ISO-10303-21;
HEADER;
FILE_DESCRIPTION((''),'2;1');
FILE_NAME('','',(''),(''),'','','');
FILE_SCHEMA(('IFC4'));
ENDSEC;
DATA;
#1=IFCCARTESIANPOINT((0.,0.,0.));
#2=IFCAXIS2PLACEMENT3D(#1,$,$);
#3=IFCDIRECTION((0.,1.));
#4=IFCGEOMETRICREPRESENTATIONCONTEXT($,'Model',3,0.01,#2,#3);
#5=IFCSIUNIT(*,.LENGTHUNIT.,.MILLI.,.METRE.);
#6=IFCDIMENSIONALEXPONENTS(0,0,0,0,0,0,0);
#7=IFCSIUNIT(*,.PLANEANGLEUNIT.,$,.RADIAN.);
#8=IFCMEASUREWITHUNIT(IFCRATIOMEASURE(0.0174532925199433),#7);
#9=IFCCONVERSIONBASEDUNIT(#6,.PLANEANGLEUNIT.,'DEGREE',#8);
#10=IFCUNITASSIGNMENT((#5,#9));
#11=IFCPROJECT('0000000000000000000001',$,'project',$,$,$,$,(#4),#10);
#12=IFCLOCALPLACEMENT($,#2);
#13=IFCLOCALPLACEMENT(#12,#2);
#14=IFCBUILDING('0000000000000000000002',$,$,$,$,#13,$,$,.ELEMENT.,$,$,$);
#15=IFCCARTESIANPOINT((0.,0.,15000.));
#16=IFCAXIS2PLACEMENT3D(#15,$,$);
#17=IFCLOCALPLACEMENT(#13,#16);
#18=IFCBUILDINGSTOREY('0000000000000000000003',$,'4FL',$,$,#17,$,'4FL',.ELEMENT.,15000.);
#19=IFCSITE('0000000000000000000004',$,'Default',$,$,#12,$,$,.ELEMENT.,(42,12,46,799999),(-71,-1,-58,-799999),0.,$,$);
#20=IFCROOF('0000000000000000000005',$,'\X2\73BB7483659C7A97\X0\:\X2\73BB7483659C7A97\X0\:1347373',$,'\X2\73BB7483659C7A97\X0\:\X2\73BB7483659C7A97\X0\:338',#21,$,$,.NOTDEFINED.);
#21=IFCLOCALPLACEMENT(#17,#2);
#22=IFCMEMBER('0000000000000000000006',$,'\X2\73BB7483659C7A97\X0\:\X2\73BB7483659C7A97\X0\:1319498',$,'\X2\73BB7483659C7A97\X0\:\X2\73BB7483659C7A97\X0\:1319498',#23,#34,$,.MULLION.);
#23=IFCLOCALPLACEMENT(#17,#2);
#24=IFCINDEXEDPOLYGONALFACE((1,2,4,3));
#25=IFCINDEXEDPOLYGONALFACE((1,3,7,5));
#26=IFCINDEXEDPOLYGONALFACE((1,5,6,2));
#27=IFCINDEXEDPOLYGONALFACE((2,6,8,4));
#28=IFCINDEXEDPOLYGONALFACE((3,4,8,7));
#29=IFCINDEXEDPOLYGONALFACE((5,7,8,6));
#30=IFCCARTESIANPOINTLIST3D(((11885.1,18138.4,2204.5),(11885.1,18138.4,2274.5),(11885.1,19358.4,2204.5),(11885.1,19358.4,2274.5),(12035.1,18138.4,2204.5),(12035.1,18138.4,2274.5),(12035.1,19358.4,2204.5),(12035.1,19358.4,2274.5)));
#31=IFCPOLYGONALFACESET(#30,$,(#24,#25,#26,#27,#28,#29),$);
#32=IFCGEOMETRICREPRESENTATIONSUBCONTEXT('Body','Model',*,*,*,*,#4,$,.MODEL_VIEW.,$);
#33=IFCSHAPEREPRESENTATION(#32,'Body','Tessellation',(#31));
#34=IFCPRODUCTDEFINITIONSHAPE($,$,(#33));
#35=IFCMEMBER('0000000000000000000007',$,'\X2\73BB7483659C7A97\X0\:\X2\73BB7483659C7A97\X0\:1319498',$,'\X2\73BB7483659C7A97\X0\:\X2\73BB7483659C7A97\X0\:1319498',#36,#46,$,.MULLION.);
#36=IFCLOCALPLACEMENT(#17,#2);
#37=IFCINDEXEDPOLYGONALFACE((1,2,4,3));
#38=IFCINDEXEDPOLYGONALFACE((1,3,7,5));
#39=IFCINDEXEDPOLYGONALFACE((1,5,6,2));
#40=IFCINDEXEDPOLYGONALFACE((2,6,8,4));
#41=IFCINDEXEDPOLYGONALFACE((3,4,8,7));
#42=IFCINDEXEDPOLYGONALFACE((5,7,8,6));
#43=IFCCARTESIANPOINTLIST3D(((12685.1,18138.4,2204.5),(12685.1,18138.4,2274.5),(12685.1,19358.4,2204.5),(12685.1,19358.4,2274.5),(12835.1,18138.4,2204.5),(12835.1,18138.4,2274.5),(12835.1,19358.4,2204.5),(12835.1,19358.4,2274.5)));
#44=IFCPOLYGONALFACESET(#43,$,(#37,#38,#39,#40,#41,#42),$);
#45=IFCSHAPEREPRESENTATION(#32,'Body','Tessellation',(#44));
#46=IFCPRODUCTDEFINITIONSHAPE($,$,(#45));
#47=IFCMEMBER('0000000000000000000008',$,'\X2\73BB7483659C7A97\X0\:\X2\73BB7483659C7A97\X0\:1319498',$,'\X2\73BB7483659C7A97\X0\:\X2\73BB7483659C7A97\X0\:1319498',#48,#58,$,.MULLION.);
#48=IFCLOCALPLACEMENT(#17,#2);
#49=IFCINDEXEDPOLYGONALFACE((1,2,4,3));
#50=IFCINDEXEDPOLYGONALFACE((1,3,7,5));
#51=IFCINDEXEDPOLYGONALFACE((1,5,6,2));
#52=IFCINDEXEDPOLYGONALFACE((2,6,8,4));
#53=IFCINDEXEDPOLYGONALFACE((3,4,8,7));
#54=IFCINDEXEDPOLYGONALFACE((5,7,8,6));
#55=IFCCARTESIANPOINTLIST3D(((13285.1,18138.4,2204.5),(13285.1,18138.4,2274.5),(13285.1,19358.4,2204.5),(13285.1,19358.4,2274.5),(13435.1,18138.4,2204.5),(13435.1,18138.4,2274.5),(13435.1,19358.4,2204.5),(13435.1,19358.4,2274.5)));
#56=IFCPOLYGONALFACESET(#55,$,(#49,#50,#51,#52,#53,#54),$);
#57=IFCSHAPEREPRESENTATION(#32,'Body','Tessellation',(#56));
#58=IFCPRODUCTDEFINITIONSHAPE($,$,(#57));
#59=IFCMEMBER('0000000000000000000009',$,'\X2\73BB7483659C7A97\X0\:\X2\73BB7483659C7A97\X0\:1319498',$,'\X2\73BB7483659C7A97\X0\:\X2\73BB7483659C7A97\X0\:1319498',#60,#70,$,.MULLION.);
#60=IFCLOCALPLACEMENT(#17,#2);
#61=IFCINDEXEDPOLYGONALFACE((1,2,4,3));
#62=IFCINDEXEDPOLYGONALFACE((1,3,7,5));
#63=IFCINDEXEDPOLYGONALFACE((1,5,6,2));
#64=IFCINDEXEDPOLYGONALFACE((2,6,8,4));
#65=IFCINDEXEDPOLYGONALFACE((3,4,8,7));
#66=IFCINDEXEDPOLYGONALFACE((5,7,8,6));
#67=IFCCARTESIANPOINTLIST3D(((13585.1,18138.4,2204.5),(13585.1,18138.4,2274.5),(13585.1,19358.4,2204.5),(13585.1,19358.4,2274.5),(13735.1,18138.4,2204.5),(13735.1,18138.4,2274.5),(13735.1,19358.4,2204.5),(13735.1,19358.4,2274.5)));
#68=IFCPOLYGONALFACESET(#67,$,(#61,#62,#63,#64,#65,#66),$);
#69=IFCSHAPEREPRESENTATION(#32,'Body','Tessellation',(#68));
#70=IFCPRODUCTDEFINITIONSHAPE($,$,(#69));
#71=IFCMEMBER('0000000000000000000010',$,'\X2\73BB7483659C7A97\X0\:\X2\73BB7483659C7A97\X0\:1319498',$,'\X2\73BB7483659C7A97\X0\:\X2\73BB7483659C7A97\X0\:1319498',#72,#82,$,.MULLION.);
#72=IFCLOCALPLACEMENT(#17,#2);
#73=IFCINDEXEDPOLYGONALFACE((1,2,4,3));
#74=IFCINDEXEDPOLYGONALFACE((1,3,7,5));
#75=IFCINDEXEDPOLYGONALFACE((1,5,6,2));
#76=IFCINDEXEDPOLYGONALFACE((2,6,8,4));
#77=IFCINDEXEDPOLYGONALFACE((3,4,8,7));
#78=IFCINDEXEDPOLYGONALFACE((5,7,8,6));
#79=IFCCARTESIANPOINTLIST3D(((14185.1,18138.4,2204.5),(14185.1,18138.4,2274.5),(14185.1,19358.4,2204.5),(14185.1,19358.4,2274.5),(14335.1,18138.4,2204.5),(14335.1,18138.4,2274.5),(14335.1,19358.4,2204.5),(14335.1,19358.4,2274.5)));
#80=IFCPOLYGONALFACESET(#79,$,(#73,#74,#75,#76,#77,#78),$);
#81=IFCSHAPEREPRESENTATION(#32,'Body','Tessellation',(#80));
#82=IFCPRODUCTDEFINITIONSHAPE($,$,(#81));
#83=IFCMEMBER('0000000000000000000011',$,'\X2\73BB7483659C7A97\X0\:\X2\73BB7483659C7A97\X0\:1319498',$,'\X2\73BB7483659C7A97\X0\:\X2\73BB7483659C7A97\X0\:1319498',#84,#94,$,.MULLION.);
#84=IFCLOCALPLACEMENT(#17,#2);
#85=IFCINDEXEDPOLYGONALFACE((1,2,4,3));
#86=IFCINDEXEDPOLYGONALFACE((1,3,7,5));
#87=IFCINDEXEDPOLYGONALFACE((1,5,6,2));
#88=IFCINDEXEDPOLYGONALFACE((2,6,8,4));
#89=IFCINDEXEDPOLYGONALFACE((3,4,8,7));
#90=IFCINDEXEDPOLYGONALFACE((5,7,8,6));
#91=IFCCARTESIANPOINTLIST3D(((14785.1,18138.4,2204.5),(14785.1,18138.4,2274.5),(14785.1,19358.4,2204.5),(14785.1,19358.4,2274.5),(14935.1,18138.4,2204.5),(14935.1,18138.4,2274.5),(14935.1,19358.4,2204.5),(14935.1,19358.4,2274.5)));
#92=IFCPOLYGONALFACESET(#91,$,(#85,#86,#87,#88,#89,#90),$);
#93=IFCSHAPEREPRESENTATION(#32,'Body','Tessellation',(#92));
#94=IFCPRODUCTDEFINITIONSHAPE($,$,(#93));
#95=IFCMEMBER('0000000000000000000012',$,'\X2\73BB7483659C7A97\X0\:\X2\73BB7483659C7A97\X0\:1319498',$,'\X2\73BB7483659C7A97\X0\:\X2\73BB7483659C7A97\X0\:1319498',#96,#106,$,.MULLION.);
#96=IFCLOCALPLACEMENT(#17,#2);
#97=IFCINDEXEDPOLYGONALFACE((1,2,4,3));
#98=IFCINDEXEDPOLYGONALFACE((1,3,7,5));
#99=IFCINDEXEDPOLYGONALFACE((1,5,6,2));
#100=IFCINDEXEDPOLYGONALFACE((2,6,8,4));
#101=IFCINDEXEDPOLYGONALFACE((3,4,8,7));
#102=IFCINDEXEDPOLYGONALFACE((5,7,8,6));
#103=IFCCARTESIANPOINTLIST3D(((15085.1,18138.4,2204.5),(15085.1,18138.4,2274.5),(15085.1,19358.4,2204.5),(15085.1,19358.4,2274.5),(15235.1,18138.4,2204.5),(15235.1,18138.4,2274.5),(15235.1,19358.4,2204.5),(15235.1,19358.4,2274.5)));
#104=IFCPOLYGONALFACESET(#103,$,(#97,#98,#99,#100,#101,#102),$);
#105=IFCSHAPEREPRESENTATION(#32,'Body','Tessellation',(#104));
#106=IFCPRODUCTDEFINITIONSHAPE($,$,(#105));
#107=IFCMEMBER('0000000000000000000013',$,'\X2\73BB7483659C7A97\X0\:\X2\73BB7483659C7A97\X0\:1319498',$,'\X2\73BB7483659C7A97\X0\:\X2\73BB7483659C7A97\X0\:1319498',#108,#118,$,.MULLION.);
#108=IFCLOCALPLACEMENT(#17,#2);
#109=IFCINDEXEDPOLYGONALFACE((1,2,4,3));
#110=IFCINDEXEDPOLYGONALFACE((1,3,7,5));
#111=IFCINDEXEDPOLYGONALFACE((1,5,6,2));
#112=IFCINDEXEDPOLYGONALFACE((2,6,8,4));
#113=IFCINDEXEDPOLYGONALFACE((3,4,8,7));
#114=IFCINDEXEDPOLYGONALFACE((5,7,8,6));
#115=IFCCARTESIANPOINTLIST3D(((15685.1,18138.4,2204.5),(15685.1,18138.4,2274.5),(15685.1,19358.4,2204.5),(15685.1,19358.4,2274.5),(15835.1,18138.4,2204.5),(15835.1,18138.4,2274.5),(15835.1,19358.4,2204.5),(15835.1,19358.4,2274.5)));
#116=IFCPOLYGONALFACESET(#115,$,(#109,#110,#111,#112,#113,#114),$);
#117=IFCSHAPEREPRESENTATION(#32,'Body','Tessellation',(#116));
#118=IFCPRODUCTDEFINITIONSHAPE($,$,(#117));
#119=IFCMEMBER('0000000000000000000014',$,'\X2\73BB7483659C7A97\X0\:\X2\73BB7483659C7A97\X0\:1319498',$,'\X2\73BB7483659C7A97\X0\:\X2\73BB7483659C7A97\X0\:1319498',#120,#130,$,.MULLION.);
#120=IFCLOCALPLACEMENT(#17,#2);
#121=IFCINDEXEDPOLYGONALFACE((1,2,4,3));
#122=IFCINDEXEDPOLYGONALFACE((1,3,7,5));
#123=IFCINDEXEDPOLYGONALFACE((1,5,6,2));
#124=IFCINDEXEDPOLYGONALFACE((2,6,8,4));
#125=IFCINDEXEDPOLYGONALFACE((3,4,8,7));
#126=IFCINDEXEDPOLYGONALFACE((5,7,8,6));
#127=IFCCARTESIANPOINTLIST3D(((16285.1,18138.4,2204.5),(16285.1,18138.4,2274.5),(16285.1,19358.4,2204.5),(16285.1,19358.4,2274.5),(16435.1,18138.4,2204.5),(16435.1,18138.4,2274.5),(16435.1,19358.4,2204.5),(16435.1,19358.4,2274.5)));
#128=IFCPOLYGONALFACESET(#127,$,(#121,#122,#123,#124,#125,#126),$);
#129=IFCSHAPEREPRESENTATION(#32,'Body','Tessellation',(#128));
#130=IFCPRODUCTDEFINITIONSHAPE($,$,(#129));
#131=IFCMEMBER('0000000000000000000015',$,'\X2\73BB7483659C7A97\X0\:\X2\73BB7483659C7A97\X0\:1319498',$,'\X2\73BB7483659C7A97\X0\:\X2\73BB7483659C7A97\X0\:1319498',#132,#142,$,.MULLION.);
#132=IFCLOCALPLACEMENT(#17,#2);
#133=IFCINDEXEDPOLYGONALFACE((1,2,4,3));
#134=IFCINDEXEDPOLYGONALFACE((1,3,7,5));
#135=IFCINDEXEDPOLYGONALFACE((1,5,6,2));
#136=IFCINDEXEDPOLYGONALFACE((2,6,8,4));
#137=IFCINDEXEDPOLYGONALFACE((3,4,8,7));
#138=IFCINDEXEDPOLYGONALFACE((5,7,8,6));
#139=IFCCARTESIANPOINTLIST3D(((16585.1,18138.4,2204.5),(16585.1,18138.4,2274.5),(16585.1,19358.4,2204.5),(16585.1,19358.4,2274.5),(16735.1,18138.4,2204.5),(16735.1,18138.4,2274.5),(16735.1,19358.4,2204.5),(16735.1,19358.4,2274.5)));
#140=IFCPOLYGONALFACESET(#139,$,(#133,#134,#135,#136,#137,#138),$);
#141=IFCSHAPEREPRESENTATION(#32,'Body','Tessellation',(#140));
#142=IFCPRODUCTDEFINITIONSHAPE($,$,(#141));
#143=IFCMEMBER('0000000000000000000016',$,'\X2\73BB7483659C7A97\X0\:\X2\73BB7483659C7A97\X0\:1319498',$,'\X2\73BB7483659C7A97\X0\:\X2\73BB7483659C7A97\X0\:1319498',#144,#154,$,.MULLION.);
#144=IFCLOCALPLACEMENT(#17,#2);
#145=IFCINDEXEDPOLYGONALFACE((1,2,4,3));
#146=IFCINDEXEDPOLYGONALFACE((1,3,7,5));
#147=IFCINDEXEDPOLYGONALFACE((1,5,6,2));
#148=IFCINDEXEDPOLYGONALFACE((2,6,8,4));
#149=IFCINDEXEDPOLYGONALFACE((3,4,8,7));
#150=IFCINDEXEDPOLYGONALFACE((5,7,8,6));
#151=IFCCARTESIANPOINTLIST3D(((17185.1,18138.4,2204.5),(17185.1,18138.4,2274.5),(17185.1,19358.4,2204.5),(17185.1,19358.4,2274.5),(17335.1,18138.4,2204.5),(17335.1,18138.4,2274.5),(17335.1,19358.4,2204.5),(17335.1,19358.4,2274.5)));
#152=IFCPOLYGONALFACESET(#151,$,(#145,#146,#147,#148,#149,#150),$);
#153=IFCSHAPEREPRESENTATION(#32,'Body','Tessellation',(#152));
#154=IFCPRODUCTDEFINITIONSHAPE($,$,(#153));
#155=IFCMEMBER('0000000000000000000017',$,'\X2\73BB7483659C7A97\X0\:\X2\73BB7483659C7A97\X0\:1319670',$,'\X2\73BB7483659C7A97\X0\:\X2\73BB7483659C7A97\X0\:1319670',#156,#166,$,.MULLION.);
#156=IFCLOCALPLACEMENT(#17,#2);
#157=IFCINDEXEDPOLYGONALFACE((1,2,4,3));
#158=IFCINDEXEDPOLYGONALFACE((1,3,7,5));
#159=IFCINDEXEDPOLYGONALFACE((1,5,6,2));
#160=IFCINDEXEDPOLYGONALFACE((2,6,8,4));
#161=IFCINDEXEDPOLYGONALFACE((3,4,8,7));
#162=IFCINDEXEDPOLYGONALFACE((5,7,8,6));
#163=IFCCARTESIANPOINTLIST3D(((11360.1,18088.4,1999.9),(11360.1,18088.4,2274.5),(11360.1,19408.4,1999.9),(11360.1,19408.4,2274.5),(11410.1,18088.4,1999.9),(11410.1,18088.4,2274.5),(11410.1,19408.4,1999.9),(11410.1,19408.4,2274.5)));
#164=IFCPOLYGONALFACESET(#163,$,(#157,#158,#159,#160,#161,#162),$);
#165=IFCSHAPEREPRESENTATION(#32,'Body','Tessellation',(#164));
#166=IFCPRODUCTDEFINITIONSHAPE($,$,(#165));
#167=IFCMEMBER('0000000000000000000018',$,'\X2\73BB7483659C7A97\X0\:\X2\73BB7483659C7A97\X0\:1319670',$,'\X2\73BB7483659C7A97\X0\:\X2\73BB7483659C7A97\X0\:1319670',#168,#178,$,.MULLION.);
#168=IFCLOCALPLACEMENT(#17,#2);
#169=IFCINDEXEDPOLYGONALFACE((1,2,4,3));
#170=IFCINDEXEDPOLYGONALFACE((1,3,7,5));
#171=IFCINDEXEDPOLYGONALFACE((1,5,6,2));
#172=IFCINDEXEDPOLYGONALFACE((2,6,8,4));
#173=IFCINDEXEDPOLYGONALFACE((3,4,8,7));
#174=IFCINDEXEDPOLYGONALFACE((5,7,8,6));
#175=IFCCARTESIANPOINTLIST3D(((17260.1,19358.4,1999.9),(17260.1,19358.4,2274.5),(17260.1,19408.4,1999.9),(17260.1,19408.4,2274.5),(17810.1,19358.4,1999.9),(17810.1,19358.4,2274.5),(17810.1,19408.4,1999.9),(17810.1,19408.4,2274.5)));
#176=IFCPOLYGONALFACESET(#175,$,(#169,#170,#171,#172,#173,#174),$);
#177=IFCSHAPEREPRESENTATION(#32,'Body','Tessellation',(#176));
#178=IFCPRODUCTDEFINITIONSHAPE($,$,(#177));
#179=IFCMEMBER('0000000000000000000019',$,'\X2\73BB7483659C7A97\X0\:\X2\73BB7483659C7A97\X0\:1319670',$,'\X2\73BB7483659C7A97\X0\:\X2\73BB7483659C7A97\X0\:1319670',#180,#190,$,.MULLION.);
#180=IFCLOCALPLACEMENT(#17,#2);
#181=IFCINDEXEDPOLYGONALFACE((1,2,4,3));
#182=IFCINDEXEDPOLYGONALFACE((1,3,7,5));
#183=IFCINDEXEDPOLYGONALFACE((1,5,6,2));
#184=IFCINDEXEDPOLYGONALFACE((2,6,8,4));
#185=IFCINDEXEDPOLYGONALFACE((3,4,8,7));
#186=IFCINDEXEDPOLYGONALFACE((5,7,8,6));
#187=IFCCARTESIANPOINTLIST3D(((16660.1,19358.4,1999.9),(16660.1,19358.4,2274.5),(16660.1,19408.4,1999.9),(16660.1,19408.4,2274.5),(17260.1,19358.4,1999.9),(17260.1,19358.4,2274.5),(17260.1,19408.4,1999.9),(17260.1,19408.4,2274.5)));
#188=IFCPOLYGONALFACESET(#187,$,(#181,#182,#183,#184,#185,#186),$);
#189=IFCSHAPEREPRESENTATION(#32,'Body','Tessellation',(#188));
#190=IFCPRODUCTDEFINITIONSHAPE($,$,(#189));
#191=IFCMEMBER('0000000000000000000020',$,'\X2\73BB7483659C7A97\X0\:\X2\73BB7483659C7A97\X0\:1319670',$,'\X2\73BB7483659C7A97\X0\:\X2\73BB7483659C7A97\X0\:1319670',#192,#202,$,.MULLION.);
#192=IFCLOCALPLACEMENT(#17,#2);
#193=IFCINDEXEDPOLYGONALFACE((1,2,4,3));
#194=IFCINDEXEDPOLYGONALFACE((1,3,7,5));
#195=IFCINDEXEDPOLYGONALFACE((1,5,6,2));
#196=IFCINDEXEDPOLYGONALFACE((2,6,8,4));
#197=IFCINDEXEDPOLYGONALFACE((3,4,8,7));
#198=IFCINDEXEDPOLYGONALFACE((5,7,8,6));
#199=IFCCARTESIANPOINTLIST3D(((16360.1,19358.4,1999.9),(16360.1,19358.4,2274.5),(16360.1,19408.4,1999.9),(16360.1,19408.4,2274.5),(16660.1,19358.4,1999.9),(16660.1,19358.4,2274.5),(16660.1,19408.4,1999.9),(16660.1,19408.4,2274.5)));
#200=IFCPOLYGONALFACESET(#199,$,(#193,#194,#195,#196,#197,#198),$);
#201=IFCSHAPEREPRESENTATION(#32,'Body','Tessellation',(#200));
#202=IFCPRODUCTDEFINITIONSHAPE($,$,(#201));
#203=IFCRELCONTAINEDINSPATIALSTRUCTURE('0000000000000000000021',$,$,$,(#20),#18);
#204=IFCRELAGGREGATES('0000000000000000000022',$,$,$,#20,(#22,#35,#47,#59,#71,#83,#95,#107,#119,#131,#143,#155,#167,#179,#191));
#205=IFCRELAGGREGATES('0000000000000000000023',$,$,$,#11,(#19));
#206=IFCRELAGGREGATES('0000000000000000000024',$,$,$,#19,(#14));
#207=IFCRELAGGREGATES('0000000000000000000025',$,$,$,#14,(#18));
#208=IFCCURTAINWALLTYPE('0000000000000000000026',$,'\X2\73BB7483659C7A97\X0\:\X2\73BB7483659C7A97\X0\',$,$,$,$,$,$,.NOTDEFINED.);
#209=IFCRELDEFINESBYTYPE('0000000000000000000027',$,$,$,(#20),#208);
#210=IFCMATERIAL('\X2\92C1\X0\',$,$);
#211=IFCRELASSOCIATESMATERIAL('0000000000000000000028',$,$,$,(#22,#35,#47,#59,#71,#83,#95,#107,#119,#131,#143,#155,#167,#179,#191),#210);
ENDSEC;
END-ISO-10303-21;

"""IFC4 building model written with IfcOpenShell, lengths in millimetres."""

from ifc_helpers import new_model, entity, si_unit, converted_unit, direction, frame, frame_2d, origin, place, context, subcontext, project, spatial, rectangle, extrude, material, type_object, element, aggregate, save


model = new_model("IFC4")

# Units and contexts
model_context = context("Model", 3, precision=0.01, world=origin(), true_north=direction((0.0, 1.0)))
body_context = subcontext(model_context, "Body", "Model", "MODEL_VIEW")
ifc_project = project(units=[si_unit("LENGTHUNIT", "METRE", prefix="MILLI"), converted_unit("PLANEANGLEUNIT", "DEGREE", entity("IfcRatioMeasure", 0.0174532925199433), si_unit("PLANEANGLEUNIT", "RADIAN"), dimensions=[0, 0, 0, 0, 0, 0, 0])], contexts=[model_context])

# Site, building, storey
site_placement = place(None, origin())
site = spatial("IfcSite", under=ifc_project, at=site_placement, Name="Default", CompositionType="ELEMENT", RefLatitude=(42, 12, 46, 799999), RefLongitude=(-71, -1, -58, -799999), RefElevation=0.0)
building_placement = place(site_placement, origin())
building = spatial("IfcBuilding", under=site, at=building_placement, CompositionType="ELEMENT")
storey_placement = place(building_placement, frame((0.0, 0.0, 15000.0)))
storey = spatial("IfcBuildingStorey", under=building, at=storey_placement, Name="4FL", LongName="4FL", CompositionType="ELEMENT", Elevation=15000.0)

# Roof, members
curtain_wall_type = type_object("IfcCurtainWallType", Name="玻璃斜窗:玻璃斜窗", PredefinedType="NOTDEFINED")
roof_1_placement = place(storey_placement, frame((0.0, 0.0, -15000.0)))
roof_1 = element("IfcRoof", 1, at=roof_1_placement, inside=storey, type_object=curtain_wall_type, Name="玻璃斜窗:玻璃斜窗:1347373", ObjectType="玻璃斜窗:玻璃斜窗:338", PredefinedType="NOTDEFINED")
ifc_material = material(Name="鋁")
member_1_placement = place(roof_1_placement, frame((0.0, 0.0, 15000.0)))
member_1 = element("IfcMember", 2, at=member_1_placement, material=ifc_material, Name="玻璃斜窗:玻璃斜窗:1319498", ObjectType="玻璃斜窗:玻璃斜窗:1319498", PredefinedType="MULLION", context=body_context, shape_type="SweptSolid", body=[
    extrude(rectangle(XDim=70.0, YDim=150.0, at=frame_2d((0.0, 0.0), x_axis=(1.0, 0.0))), frame((11960.1, 18138.4, 2239.5), z_axis=(0.0, 1.0, 0.0), x_axis=(0.0, 0.0, -1.0)), (0.0, 0.0, 1.0), 1220.0),
])
member_2_placement = place(roof_1_placement, frame((0.0, 0.0, 15000.0)))
member_2 = element("IfcMember", 3, at=member_2_placement, material=ifc_material, Name="玻璃斜窗:玻璃斜窗:1319498", ObjectType="玻璃斜窗:玻璃斜窗:1319498", PredefinedType="MULLION", context=body_context, shape_type="SweptSolid", body=[
    extrude(rectangle(XDim=70.0, YDim=150.0, at=frame_2d((0.0, 0.0), x_axis=(1.0, 0.0))), frame((12760.1, 18138.4, 2239.5), z_axis=(0.0, 1.0, 0.0), x_axis=(0.0, 0.0, -1.0)), (0.0, 0.0, 1.0), 1220.0),
])
member_3_placement = place(roof_1_placement, frame((0.0, 0.0, 15000.0)))
member_3 = element("IfcMember", 4, at=member_3_placement, material=ifc_material, Name="玻璃斜窗:玻璃斜窗:1319498", ObjectType="玻璃斜窗:玻璃斜窗:1319498", PredefinedType="MULLION", context=body_context, shape_type="SweptSolid", body=[
    extrude(rectangle(XDim=70.0, YDim=150.0, at=frame_2d((0.0, 0.0), x_axis=(1.0, 0.0))), frame((13360.1, 18138.4, 2239.5), z_axis=(0.0, 1.0, 0.0), x_axis=(0.0, 0.0, -1.0)), (0.0, 0.0, 1.0), 1220.0),
])
member_4_placement = place(roof_1_placement, frame((0.0, 0.0, 15000.0)))
member_4 = element("IfcMember", 5, at=member_4_placement, material=ifc_material, Name="玻璃斜窗:玻璃斜窗:1319498", ObjectType="玻璃斜窗:玻璃斜窗:1319498", PredefinedType="MULLION", context=body_context, shape_type="SweptSolid", body=[
    extrude(rectangle(XDim=70.0, YDim=150.0, at=frame_2d((0.0, 0.0), x_axis=(1.0, 0.0))), frame((13660.1, 18138.4, 2239.5), z_axis=(0.0, 1.0, 0.0), x_axis=(0.0, 0.0, -1.0)), (0.0, 0.0, 1.0), 1220.0),
])
member_5_placement = place(roof_1_placement, frame((0.0, 0.0, 15000.0)))
member_5 = element("IfcMember", 6, at=member_5_placement, material=ifc_material, Name="玻璃斜窗:玻璃斜窗:1319498", ObjectType="玻璃斜窗:玻璃斜窗:1319498", PredefinedType="MULLION", context=body_context, shape_type="SweptSolid", body=[
    extrude(rectangle(XDim=70.0, YDim=150.0, at=frame_2d((0.0, 0.0), x_axis=(1.0, 0.0))), frame((14260.1, 18138.4, 2239.5), z_axis=(0.0, 1.0, 0.0), x_axis=(0.0, 0.0, -1.0)), (0.0, 0.0, 1.0), 1220.0),
])
member_6_placement = place(roof_1_placement, frame((0.0, 0.0, 15000.0)))
member_6 = element("IfcMember", 7, at=member_6_placement, material=ifc_material, Name="玻璃斜窗:玻璃斜窗:1319498", ObjectType="玻璃斜窗:玻璃斜窗:1319498", PredefinedType="MULLION", context=body_context, shape_type="SweptSolid", body=[
    extrude(rectangle(XDim=70.0, YDim=150.0, at=frame_2d((0.0, 0.0), x_axis=(1.0, 0.0))), frame((14860.1, 18138.4, 2239.5), z_axis=(0.0, 1.0, 0.0), x_axis=(0.0, 0.0, -1.0)), (0.0, 0.0, 1.0), 1220.0),
])
member_7_placement = place(roof_1_placement, frame((0.0, 0.0, 15000.0)))
member_7 = element("IfcMember", 8, at=member_7_placement, material=ifc_material, Name="玻璃斜窗:玻璃斜窗:1319498", ObjectType="玻璃斜窗:玻璃斜窗:1319498", PredefinedType="MULLION", context=body_context, shape_type="SweptSolid", body=[
    extrude(rectangle(XDim=70.0, YDim=150.0, at=frame_2d((0.0, 0.0), x_axis=(1.0, 0.0))), frame((15160.1, 18138.4, 2239.5), z_axis=(0.0, 1.0, 0.0), x_axis=(0.0, 0.0, -1.0)), (0.0, 0.0, 1.0), 1220.0),
])
member_8_placement = place(roof_1_placement, frame((0.0, 0.0, 15000.0)))
member_8 = element("IfcMember", 9, at=member_8_placement, material=ifc_material, Name="玻璃斜窗:玻璃斜窗:1319498", ObjectType="玻璃斜窗:玻璃斜窗:1319498", PredefinedType="MULLION", context=body_context, shape_type="SweptSolid", body=[
    extrude(rectangle(XDim=70.0, YDim=150.0, at=frame_2d((0.0, 0.0), x_axis=(1.0, 0.0))), frame((15760.1, 18138.4, 2239.5), z_axis=(0.0, 1.0, 0.0), x_axis=(0.0, 0.0, -1.0)), (0.0, 0.0, 1.0), 1220.0),
])
member_9_placement = place(roof_1_placement, frame((0.0, 0.0, 15000.0)))
member_9 = element("IfcMember", 10, at=member_9_placement, material=ifc_material, Name="玻璃斜窗:玻璃斜窗:1319498", ObjectType="玻璃斜窗:玻璃斜窗:1319498", PredefinedType="MULLION", context=body_context, shape_type="SweptSolid", body=[
    extrude(rectangle(XDim=70.0, YDim=150.0, at=frame_2d((0.0, 0.0), x_axis=(1.0, 0.0))), frame((16360.1, 18138.4, 2239.5), z_axis=(0.0, 1.0, 0.0), x_axis=(0.0, 0.0, -1.0)), (0.0, 0.0, 1.0), 1220.0),
])
member_10_placement = place(roof_1_placement, frame((0.0, 0.0, 15000.0)))
member_10 = element("IfcMember", 11, at=member_10_placement, material=ifc_material, Name="玻璃斜窗:玻璃斜窗:1319498", ObjectType="玻璃斜窗:玻璃斜窗:1319498", PredefinedType="MULLION", context=body_context, shape_type="SweptSolid", body=[
    extrude(rectangle(XDim=70.0, YDim=150.0, at=frame_2d((0.0, 0.0), x_axis=(1.0, 0.0))), frame((16660.1, 18138.4, 2239.5), z_axis=(0.0, 1.0, 0.0), x_axis=(0.0, 0.0, -1.0)), (0.0, 0.0, 1.0), 1220.0),
])
member_11_placement = place(roof_1_placement, frame((0.0, 0.0, 15000.0)))
member_11 = element("IfcMember", 12, at=member_11_placement, material=ifc_material, Name="玻璃斜窗:玻璃斜窗:1319498", ObjectType="玻璃斜窗:玻璃斜窗:1319498", PredefinedType="MULLION", context=body_context, shape_type="SweptSolid", body=[
    extrude(rectangle(XDim=70.0, YDim=150.0, at=frame_2d((0.0, 0.0), x_axis=(1.0, 0.0))), frame((17260.1, 18138.4, 2239.5), z_axis=(0.0, 1.0, 0.0), x_axis=(0.0, 0.0, -1.0)), (0.0, 0.0, 1.0), 1220.0),
])
member_12_placement = place(roof_1_placement, frame((0.0, 0.0, 15000.0)))
member_12 = element("IfcMember", 13, at=member_12_placement, material=ifc_material, Name="玻璃斜窗:玻璃斜窗:1319670", ObjectType="玻璃斜窗:玻璃斜窗:1319670", PredefinedType="MULLION", context=body_context, shape_type="SweptSolid", body=[
    extrude(rectangle(XDim=274.5, YDim=50.0, at=frame_2d((0.0, 0.0), x_axis=(1.0, 0.0))), frame((11385.1, 18088.4, 2137.2), z_axis=(0.0, 1.0, 0.0), x_axis=(0.0, 0.0, -1.0)), (0.0, 0.0, 1.0), 1320.0),
])
member_13_placement = place(roof_1_placement, frame((0.0, 0.0, 15000.0)))
member_13 = element("IfcMember", 14, at=member_13_placement, material=ifc_material, Name="玻璃斜窗:玻璃斜窗:1319670", ObjectType="玻璃斜窗:玻璃斜窗:1319670", PredefinedType="MULLION", context=body_context, shape_type="SweptSolid", body=[
    extrude(rectangle(XDim=274.5, YDim=50.0, at=frame_2d((0.0, 0.0), x_axis=(1.0, 0.0))), frame((17260.1, 19383.4, 2137.2), z_axis=(1.0, 0.0, 0.0), x_axis=(0.0, 0.0, -1.0)), (0.0, 0.0, 1.0), 550.0),
])
member_14_placement = place(roof_1_placement, frame((0.0, 0.0, 15000.0)))
member_14 = element("IfcMember", 15, at=member_14_placement, material=ifc_material, Name="玻璃斜窗:玻璃斜窗:1319670", ObjectType="玻璃斜窗:玻璃斜窗:1319670", PredefinedType="MULLION", context=body_context, shape_type="SweptSolid", body=[
    extrude(rectangle(XDim=274.5, YDim=50.0, at=frame_2d((0.0, 0.0), x_axis=(1.0, 0.0))), frame((16660.1, 19383.4, 2137.2), z_axis=(1.0, 0.0, 0.0), x_axis=(0.0, 0.0, -1.0)), (0.0, 0.0, 1.0), 600.0),
])
member_15_placement = place(roof_1_placement, frame((0.0, 0.0, 15000.0)))
member_15 = element("IfcMember", 16, at=member_15_placement, material=ifc_material, Name="玻璃斜窗:玻璃斜窗:1319670", ObjectType="玻璃斜窗:玻璃斜窗:1319670", PredefinedType="MULLION", context=body_context, shape_type="SweptSolid", body=[
    extrude(rectangle(XDim=274.5, YDim=50.0, at=frame_2d((0.0, 0.0), x_axis=(1.0, 0.0))), frame((16360.1, 19383.4, 2137.2), z_axis=(1.0, 0.0, 0.0), x_axis=(0.0, 0.0, -1.0)), (0.0, 0.0, 1.0), 300.0),
])
aggregate(roof_1, [member_1, member_2, member_3, member_4, member_5, member_6, member_7, member_8, member_9, member_10, member_11, member_12, member_13, member_14, member_15])

save(model, "model.ifc")
